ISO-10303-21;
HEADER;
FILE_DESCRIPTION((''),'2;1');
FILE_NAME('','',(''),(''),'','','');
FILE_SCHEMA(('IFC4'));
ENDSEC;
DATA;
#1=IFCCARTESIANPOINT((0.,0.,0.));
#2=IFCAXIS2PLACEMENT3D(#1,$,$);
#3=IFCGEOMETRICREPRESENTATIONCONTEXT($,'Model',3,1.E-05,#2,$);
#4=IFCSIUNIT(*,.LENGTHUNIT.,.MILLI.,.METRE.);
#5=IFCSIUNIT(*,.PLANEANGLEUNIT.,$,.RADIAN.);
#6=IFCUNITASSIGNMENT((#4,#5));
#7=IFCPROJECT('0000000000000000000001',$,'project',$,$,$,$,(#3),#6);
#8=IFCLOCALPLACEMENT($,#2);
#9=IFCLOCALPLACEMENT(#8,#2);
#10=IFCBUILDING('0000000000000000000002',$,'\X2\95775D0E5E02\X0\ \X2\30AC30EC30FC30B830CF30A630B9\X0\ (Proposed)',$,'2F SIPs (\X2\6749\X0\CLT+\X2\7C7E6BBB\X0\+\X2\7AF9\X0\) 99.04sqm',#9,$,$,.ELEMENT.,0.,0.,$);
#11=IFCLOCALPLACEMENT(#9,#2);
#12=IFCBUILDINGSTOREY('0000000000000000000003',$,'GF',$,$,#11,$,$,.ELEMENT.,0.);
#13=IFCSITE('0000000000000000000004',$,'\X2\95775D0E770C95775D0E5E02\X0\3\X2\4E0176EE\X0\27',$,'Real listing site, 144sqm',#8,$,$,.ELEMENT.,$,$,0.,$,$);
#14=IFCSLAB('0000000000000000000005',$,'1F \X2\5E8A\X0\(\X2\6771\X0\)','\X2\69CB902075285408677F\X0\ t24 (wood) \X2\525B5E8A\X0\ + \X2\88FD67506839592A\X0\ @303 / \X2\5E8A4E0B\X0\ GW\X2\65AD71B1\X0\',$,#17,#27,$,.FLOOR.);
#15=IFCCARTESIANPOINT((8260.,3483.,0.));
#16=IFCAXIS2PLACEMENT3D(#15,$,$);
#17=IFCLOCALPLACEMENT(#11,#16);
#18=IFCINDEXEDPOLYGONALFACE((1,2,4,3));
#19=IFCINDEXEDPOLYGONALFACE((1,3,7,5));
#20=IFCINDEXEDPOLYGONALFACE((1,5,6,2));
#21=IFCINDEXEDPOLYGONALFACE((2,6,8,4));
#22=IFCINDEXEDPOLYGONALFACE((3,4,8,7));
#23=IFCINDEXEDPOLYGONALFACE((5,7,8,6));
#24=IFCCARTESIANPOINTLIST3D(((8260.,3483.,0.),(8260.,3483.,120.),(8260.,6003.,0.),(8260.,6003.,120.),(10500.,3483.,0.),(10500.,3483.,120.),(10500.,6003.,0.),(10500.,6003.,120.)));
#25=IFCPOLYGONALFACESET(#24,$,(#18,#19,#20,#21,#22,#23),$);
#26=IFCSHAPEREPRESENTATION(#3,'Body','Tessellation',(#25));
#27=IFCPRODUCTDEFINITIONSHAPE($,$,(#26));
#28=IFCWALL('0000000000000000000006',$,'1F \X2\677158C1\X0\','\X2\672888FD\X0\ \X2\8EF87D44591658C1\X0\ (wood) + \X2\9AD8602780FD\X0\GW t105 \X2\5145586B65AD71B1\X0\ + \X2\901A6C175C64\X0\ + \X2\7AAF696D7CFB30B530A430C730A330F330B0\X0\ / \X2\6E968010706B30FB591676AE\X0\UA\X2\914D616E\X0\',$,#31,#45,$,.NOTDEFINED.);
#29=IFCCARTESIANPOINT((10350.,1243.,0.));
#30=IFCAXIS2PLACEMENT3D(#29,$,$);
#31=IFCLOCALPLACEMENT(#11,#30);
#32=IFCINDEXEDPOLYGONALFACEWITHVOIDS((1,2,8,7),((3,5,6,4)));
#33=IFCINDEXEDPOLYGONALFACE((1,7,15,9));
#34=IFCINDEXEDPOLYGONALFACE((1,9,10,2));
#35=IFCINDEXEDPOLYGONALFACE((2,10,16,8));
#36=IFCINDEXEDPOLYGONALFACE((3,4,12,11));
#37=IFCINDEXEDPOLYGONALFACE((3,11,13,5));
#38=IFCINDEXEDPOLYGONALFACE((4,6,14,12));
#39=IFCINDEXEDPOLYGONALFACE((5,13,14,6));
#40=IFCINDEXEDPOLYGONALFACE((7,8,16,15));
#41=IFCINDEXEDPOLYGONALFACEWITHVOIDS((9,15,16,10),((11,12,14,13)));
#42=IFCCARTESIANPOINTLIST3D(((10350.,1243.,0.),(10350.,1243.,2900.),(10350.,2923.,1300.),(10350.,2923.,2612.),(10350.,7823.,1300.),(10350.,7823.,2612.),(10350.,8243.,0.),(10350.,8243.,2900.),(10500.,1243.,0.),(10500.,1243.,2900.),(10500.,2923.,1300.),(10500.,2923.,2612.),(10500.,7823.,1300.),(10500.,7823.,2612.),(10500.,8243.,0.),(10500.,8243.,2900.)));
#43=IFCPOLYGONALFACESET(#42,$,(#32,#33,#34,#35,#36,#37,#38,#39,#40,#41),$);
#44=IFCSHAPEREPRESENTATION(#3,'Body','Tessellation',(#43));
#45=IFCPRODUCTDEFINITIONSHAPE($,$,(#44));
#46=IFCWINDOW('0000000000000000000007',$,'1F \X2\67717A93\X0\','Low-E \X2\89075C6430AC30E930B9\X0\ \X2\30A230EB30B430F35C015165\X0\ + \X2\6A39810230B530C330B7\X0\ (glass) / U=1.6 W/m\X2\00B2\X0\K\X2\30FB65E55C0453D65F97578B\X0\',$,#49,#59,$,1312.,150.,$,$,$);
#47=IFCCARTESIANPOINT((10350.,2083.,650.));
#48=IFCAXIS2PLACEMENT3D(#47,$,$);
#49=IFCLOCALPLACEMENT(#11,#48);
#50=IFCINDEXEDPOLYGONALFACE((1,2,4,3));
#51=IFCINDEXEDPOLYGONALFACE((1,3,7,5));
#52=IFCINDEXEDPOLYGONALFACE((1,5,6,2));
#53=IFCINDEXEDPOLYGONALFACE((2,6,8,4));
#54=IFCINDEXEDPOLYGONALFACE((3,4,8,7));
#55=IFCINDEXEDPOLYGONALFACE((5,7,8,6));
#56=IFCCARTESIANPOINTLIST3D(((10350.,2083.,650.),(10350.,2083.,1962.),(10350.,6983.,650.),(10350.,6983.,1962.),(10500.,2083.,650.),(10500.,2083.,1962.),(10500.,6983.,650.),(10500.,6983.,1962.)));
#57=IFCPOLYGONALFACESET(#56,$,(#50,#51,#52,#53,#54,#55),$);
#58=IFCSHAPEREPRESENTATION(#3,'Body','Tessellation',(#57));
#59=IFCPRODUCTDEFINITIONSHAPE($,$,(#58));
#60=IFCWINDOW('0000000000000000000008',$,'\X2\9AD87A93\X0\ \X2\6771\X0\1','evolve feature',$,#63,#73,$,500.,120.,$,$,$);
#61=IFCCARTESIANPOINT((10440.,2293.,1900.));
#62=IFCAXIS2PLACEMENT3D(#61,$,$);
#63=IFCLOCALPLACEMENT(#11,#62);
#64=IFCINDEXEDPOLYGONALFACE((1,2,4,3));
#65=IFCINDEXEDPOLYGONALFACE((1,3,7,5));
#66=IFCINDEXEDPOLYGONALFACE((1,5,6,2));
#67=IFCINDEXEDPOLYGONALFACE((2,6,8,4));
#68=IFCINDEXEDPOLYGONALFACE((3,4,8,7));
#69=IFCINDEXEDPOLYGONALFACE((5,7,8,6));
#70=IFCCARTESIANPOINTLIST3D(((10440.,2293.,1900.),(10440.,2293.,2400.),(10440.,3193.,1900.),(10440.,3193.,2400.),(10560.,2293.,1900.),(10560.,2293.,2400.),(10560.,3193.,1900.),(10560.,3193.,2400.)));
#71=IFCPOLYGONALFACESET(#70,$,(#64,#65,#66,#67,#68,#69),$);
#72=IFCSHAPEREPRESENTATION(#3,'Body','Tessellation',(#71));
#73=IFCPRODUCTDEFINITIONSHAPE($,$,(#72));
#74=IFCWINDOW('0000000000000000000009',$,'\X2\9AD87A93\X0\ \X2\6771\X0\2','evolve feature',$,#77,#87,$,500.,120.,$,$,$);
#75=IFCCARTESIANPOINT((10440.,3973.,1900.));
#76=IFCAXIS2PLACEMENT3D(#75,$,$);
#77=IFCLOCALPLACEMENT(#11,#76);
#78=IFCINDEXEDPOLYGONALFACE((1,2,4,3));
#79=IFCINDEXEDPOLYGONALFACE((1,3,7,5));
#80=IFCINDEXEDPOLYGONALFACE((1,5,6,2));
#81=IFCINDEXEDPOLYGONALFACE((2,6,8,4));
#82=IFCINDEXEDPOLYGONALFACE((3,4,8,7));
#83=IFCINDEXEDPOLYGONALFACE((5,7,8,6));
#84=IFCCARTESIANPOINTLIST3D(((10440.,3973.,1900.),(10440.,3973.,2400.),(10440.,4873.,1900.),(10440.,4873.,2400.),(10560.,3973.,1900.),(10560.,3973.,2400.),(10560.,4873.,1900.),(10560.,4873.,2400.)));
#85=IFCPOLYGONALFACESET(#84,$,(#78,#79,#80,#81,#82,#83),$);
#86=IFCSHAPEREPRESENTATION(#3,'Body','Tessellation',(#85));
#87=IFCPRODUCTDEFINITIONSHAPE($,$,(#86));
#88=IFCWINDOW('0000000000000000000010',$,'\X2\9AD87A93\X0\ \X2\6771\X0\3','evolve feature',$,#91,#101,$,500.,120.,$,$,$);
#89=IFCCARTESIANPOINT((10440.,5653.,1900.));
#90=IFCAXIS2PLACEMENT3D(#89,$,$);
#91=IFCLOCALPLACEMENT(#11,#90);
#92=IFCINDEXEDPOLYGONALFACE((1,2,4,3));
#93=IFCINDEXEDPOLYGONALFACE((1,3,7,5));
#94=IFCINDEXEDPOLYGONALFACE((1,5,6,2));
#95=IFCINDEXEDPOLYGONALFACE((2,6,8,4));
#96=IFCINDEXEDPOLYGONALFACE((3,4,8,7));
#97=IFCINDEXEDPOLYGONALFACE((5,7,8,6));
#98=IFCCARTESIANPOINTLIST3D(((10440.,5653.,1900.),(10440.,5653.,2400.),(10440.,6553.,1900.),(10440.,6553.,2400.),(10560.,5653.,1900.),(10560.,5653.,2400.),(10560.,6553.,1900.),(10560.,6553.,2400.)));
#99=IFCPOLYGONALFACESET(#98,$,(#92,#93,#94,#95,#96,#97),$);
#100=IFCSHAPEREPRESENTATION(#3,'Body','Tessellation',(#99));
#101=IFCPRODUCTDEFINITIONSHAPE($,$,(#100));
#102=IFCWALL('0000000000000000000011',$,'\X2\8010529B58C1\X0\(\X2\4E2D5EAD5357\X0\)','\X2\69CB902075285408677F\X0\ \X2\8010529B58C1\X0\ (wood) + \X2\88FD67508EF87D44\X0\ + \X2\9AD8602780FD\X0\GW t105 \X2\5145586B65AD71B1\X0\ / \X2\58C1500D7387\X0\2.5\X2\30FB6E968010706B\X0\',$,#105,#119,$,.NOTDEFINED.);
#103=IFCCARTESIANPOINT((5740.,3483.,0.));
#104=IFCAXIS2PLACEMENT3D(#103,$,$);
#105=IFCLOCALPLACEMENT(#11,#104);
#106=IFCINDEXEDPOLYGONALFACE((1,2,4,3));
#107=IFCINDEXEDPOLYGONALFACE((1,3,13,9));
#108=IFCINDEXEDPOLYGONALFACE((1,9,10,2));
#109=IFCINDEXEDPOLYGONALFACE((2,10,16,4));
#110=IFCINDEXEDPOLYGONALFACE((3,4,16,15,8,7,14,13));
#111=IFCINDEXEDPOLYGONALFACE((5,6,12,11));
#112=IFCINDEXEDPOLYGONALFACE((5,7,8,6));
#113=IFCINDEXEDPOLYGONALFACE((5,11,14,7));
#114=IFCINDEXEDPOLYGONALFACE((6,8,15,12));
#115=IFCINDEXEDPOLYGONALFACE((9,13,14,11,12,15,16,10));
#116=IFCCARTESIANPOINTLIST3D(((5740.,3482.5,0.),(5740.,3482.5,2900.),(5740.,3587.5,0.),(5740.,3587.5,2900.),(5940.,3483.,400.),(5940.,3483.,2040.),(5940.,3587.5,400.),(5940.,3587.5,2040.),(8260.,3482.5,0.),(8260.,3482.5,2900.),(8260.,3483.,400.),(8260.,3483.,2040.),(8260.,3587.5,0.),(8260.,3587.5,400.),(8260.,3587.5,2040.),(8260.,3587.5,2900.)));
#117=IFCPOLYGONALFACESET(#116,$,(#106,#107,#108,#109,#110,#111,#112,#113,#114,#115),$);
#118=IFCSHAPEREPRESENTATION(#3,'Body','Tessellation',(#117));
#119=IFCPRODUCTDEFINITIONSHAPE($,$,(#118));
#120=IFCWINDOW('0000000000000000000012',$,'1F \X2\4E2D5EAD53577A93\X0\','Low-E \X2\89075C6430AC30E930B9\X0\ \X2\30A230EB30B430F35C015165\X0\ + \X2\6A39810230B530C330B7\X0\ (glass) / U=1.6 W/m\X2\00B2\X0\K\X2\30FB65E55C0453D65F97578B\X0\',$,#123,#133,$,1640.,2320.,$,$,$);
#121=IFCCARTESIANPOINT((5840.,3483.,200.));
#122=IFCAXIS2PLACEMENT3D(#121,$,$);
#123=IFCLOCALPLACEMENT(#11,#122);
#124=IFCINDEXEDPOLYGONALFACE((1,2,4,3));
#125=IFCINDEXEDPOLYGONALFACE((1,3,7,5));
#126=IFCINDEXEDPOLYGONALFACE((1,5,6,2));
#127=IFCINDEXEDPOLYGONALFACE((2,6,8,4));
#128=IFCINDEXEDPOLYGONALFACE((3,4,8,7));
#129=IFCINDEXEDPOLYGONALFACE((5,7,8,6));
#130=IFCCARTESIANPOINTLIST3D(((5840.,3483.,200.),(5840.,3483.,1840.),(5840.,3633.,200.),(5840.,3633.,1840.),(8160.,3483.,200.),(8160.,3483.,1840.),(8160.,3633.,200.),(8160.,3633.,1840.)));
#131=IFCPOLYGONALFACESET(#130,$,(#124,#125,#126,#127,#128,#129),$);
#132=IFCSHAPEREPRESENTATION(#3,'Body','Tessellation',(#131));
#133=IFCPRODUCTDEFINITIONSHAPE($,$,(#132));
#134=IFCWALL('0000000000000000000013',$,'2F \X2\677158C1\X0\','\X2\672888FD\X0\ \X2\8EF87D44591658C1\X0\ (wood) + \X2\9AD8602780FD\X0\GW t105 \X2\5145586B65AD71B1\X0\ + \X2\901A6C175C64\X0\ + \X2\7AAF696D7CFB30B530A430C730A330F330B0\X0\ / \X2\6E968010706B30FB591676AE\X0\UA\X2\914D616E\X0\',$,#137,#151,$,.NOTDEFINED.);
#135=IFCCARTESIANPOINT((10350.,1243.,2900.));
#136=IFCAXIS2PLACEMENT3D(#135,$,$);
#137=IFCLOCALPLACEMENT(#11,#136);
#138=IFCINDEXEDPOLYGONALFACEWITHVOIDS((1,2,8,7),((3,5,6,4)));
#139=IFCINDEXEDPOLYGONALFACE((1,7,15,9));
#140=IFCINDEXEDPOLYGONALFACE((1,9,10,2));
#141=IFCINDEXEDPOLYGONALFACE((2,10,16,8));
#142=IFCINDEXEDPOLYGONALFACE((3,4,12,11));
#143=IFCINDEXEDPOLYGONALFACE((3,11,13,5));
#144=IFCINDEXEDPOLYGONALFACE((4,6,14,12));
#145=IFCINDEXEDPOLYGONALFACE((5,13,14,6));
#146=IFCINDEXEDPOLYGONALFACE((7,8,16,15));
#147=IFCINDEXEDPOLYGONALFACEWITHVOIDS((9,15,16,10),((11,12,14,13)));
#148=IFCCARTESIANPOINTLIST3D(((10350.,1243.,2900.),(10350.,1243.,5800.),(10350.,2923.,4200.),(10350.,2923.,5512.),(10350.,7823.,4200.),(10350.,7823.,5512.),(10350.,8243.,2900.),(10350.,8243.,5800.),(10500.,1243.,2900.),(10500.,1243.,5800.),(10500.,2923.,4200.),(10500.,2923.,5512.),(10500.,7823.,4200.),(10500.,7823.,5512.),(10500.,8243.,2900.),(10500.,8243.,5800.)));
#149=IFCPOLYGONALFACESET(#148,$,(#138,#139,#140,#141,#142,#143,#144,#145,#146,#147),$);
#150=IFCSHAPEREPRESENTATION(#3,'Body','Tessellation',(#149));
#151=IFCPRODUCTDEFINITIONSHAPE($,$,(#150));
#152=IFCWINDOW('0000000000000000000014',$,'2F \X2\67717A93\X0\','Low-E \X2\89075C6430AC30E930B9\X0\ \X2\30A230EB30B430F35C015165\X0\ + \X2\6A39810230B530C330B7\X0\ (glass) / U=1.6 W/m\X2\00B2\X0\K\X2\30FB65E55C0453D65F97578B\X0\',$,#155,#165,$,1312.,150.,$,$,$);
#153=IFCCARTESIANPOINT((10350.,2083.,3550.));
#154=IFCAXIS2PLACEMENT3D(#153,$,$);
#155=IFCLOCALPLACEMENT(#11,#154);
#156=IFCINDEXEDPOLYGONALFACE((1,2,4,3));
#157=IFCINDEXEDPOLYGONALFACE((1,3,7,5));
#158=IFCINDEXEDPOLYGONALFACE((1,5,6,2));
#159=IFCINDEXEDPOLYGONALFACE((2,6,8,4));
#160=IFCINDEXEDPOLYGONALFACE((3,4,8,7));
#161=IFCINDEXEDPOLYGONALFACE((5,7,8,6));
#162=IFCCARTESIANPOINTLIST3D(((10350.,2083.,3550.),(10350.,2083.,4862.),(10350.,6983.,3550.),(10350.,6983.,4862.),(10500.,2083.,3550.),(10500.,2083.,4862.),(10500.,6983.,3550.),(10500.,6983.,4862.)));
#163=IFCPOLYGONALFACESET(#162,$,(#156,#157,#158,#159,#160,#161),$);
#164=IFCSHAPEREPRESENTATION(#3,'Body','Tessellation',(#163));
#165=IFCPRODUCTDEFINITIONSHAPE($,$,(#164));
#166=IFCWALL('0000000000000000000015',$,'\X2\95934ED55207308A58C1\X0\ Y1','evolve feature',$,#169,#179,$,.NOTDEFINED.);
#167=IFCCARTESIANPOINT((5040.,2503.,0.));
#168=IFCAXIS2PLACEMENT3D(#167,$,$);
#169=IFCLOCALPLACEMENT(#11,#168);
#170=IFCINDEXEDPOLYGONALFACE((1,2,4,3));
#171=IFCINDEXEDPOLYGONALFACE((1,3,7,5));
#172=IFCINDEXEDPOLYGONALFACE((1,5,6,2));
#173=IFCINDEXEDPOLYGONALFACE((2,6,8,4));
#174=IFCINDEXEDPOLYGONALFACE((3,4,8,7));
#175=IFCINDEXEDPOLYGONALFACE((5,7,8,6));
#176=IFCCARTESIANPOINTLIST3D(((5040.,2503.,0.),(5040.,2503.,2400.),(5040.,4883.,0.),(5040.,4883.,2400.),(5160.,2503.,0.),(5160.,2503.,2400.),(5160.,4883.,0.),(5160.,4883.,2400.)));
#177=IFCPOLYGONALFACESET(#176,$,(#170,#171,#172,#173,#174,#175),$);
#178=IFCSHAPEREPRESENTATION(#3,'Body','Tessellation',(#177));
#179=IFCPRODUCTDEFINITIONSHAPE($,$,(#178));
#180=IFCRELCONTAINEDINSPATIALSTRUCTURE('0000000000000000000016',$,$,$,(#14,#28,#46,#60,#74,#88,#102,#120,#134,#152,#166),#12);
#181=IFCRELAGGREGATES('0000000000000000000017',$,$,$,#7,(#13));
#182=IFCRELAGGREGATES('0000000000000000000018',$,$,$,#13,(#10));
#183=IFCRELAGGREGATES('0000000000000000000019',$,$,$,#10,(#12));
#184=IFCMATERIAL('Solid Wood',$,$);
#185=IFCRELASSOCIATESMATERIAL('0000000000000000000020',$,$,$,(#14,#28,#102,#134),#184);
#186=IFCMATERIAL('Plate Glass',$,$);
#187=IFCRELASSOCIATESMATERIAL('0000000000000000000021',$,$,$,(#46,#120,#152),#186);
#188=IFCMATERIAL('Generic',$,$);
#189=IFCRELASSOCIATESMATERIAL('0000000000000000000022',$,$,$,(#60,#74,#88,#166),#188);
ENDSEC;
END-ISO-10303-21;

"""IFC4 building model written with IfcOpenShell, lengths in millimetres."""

from ifc_helpers import new_model, si_unit, frame, frame_2d, origin, place, context, project, spatial, rectangle, extrude, material, element, fill, save


model = new_model("IFC4")

# Units and contexts
model_context = context("Model", 3, precision=1e-05, world=origin())
ifc_project = project(units=[si_unit("LENGTHUNIT", "METRE", prefix="MILLI"), si_unit("PLANEANGLEUNIT", "RADIAN")], contexts=[model_context])

# Site, building, storey
site_placement = place(None, origin())
site = spatial("IfcSite", under=ifc_project, at=site_placement, Name="長崎県長崎市3丁目27", ObjectType="Real listing site, 144sqm", CompositionType="ELEMENT", RefElevation=0.0)
building_placement = place(site_placement, origin())
building = spatial("IfcBuilding", under=site, at=building_placement, Name="長崎市 ガレージハウス (Proposed)", ObjectType="2F SIPs (杉CLT+籾殻+竹) 99.04sqm", CompositionType="ELEMENT", ElevationOfRefHeight=0.0, ElevationOfTerrain=0.0)
storey_placement = place(building_placement, origin())
storey = spatial("IfcBuildingStorey", under=building, at=storey_placement, Name="GF", CompositionType="ELEMENT", Elevation=0.0)

# Slab
ifc_material_1 = material(Name="Solid Wood")
slab_placement = place(storey_placement, frame((8260.0, 3483.0, 0.0)))
element("IfcSlab", 1, at=slab_placement, inside=storey, material=ifc_material_1, Name="1F 床(東)", Description="構造用合板 t24 (wood) 剛床 + 製材根太 @303 / 床下 GW断熱", PredefinedType="FLOOR", context=model_context, shape_type="SweptSolid", body=[
    extrude(rectangle(XDim=2240.0, YDim=2520.0, at=frame_2d((1120.0, 1260.0))), frame((8260.0, 3483.0, 0.0)), (0.0, 0.0, 1.0), 120.0),
])

# Wall, openings, windows
wall_1_placement = place(storey_placement, frame((10350.0, 1243.0, 0.0)))
wall_1 = element("IfcWall", 2, at=wall_1_placement, inside=storey, material=ifc_material_1, Name="1F 東壁", Description="木製 軸組外壁 (wood) + 高性能GW t105 充填断熱 + 通気層 + 窯業系サイディング / 準耐火・外皮UA配慮", PredefinedType="NOTDEFINED", context=model_context, shape_type="SweptSolid", body=[
    extrude(rectangle(XDim=150.0, YDim=7000.0, at=frame_2d((75.0, 3500.0))), frame((10350.0, 1243.0, 0.0)), (0.0, 0.0, 1.0), 2900.0),
])
opening_1_placement = place(storey_placement, frame((10350.0, 2083.0, 650.0)))
opening_1 = element("IfcOpeningElement", 3, at=opening_1_placement, cuts=wall_1, PredefinedType="NOTDEFINED", context=model_context, shape_type="SweptSolid", body=[
    extrude(rectangle(XDim=150.0, YDim=4900.0, at=frame_2d((75.0, 2450.0))), frame((10350.0, 2083.0, 650.0)), (0.0, 0.0, 1.0), 1312.0),
])
opening_2_placement = place(storey_placement, frame((10440.0, 2293.0, 1900.0)))
opening_2 = element("IfcOpeningElement", 4, at=opening_2_placement, cuts=wall_1, PredefinedType="NOTDEFINED", context=model_context, shape_type="SweptSolid", body=[
    extrude(rectangle(XDim=120.0, YDim=900.0, at=frame_2d((60.0, 450.0))), frame((10440.0, 2293.0, 1900.0)), (0.0, 0.0, 1.0), 500.0),
])
opening_3_placement = place(storey_placement, frame((10440.0, 3973.0, 1900.0)))
opening_3 = element("IfcOpeningElement", 5, at=opening_3_placement, cuts=wall_1, PredefinedType="NOTDEFINED", context=model_context, shape_type="SweptSolid", body=[
    extrude(rectangle(XDim=120.0, YDim=900.0, at=frame_2d((60.0, 450.0))), frame((10440.0, 3973.0, 1900.0)), (0.0, 0.0, 1.0), 500.0),
])
opening_4_placement = place(storey_placement, frame((10440.0, 5653.0, 1900.0)))
opening_4 = element("IfcOpeningElement", 6, at=opening_4_placement, cuts=wall_1, PredefinedType="NOTDEFINED", context=model_context, shape_type="SweptSolid", body=[
    extrude(rectangle(XDim=120.0, YDim=900.0, at=frame_2d((60.0, 450.0))), frame((10440.0, 5653.0, 1900.0)), (0.0, 0.0, 1.0), 500.0),
])
ifc_material_2 = material(Name="Plate Glass")
window_1_placement = place(storey_placement, frame((10350.0, 2083.0, 650.0)))
window_1 = element("IfcWindow", 7, at=window_1_placement, inside=storey, material=ifc_material_2, Name="1F 東窓", Description="Low-E 複層ガラス アルゴン封入 + 樹脂サッシ (glass) / U=1.6 W/m²K・日射取得型", OverallHeight=1312.0, OverallWidth=150.0, context=model_context, shape_type="SweptSolid", body=[
    extrude(rectangle(XDim=150.0, YDim=4900.0, at=frame_2d((75.0, 2450.0))), frame((10350.0, 2083.0, 650.0)), (0.0, 0.0, 1.0), 1312.0),
])
fill(opening_1, window_1)
ifc_material_3 = material(Name="Generic")
window_2_placement = place(storey_placement, frame((10440.0, 2293.0, 1900.0)))
window_2 = element("IfcWindow", 8, at=window_2_placement, inside=storey, material=ifc_material_3, Name="高窓 東1", Description="evolve feature", OverallHeight=500.0, OverallWidth=120.0, context=model_context, shape_type="SweptSolid", body=[
    extrude(rectangle(XDim=120.0, YDim=900.0, at=frame_2d((60.0, 450.0))), frame((10440.0, 2293.0, 1900.0)), (0.0, 0.0, 1.0), 500.0),
])
fill(opening_2, window_2)
window_3_placement = place(storey_placement, frame((10440.0, 3973.0, 1900.0)))
window_3 = element("IfcWindow", 9, at=window_3_placement, inside=storey, material=ifc_material_3, Name="高窓 東2", Description="evolve feature", OverallHeight=500.0, OverallWidth=120.0, context=model_context, shape_type="SweptSolid", body=[
    extrude(rectangle(XDim=120.0, YDim=900.0, at=frame_2d((60.0, 450.0))), frame((10440.0, 3973.0, 1900.0)), (0.0, 0.0, 1.0), 500.0),
])
fill(opening_3, window_3)
window_4_placement = place(storey_placement, frame((10440.0, 5653.0, 1900.0)))
window_4 = element("IfcWindow", 10, at=window_4_placement, inside=storey, material=ifc_material_3, Name="高窓 東3", Description="evolve feature", OverallHeight=500.0, OverallWidth=120.0, context=model_context, shape_type="SweptSolid", body=[
    extrude(rectangle(XDim=120.0, YDim=900.0, at=frame_2d((60.0, 450.0))), frame((10440.0, 5653.0, 1900.0)), (0.0, 0.0, 1.0), 500.0),
])
fill(opening_4, window_4)

# Wall, opening, window
wall_2_placement = place(storey_placement, frame((5740.0, 3483.0, 0.0)))
wall_2 = element("IfcWall", 11, at=wall_2_placement, inside=storey, material=ifc_material_1, Name="耐力壁(中庭南)", Description="構造用合板 耐力壁 (wood) + 製材軸組 + 高性能GW t105 充填断熱 / 壁倍率2.5・準耐火", PredefinedType="NOTDEFINED", context=model_context, shape_type="SweptSolid", body=[
    extrude(rectangle(XDim=2520.0, YDim=105.0, at=frame_2d((1260.0, 52.0))), frame((5740.0, 3483.0, 0.0)), (0.0, 0.0, 1.0), 2900.0),
])
opening_5_placement = place(storey_placement, frame((5840.0, 3483.0, 200.0)))
opening_5 = element("IfcOpeningElement", 12, at=opening_5_placement, cuts=wall_2, PredefinedType="NOTDEFINED", context=model_context, shape_type="SweptSolid", body=[
    extrude(rectangle(XDim=2320.0, YDim=150.0, at=frame_2d((1160.0, 75.0))), frame((5840.0, 3483.0, 200.0)), (0.0, 0.0, 1.0), 1640.0),
])
window_5_placement = place(storey_placement, frame((5840.0, 3483.0, 200.0)))
window_5 = element("IfcWindow", 13, at=window_5_placement, inside=storey, material=ifc_material_2, Name="1F 中庭南窓", Description="Low-E 複層ガラス アルゴン封入 + 樹脂サッシ (glass) / U=1.6 W/m²K・日射取得型", OverallHeight=1640.0, OverallWidth=2320.0, context=model_context, shape_type="SweptSolid", body=[
    extrude(rectangle(XDim=2320.0, YDim=150.0, at=frame_2d((1160.0, 75.0))), frame((5840.0, 3483.0, 200.0)), (0.0, 0.0, 1.0), 1640.0),
])
fill(opening_5, window_5)

# Wall, opening, window
wall_3_placement = place(storey_placement, frame((10350.0, 1243.0, 2900.0)))
wall_3 = element("IfcWall", 14, at=wall_3_placement, inside=storey, material=ifc_material_1, Name="2F 東壁", Description="木製 軸組外壁 (wood) + 高性能GW t105 充填断熱 + 通気層 + 窯業系サイディング / 準耐火・外皮UA配慮", PredefinedType="NOTDEFINED", context=model_context, shape_type="SweptSolid", body=[
    extrude(rectangle(XDim=150.0, YDim=7000.0, at=frame_2d((75.0, 3500.0))), frame((10350.0, 1243.0, 2900.0)), (0.0, 0.0, 1.0), 2900.0),
])
opening_6_placement = place(storey_placement, frame((10350.0, 2083.0, 3550.0)))
opening_6 = element("IfcOpeningElement", 15, at=opening_6_placement, cuts=wall_3, PredefinedType="NOTDEFINED", context=model_context, shape_type="SweptSolid", body=[
    extrude(rectangle(XDim=150.0, YDim=4900.0, at=frame_2d((75.0, 2450.0))), frame((10350.0, 2083.0, 3550.0)), (0.0, 0.0, 1.0), 1312.0),
])
window_6_placement = place(storey_placement, frame((10350.0, 2083.0, 3550.0)))
window_6 = element("IfcWindow", 16, at=window_6_placement, inside=storey, material=ifc_material_2, Name="2F 東窓", Description="Low-E 複層ガラス アルゴン封入 + 樹脂サッシ (glass) / U=1.6 W/m²K・日射取得型", OverallHeight=1312.0, OverallWidth=150.0, context=model_context, shape_type="SweptSolid", body=[
    extrude(rectangle(XDim=150.0, YDim=4900.0, at=frame_2d((75.0, 2450.0))), frame((10350.0, 2083.0, 3550.0)), (0.0, 0.0, 1.0), 1312.0),
])
fill(opening_6, window_6)

# Wall
wall_4_placement = place(storey_placement, frame((5040.0, 2503.0, 0.0)))
element("IfcWall", 17, at=wall_4_placement, inside=storey, material=ifc_material_3, Name="間仕切り壁 Y1", Description="evolve feature", PredefinedType="NOTDEFINED", context=model_context, shape_type="SweptSolid", body=[
    extrude(rectangle(XDim=120.0, YDim=2380.0, at=frame_2d((60.0, 1190.0))), frame((5040.0, 2503.0, 0.0)), (0.0, 0.0, 1.0), 2400.0),
])

save(model, "model.ifc")
